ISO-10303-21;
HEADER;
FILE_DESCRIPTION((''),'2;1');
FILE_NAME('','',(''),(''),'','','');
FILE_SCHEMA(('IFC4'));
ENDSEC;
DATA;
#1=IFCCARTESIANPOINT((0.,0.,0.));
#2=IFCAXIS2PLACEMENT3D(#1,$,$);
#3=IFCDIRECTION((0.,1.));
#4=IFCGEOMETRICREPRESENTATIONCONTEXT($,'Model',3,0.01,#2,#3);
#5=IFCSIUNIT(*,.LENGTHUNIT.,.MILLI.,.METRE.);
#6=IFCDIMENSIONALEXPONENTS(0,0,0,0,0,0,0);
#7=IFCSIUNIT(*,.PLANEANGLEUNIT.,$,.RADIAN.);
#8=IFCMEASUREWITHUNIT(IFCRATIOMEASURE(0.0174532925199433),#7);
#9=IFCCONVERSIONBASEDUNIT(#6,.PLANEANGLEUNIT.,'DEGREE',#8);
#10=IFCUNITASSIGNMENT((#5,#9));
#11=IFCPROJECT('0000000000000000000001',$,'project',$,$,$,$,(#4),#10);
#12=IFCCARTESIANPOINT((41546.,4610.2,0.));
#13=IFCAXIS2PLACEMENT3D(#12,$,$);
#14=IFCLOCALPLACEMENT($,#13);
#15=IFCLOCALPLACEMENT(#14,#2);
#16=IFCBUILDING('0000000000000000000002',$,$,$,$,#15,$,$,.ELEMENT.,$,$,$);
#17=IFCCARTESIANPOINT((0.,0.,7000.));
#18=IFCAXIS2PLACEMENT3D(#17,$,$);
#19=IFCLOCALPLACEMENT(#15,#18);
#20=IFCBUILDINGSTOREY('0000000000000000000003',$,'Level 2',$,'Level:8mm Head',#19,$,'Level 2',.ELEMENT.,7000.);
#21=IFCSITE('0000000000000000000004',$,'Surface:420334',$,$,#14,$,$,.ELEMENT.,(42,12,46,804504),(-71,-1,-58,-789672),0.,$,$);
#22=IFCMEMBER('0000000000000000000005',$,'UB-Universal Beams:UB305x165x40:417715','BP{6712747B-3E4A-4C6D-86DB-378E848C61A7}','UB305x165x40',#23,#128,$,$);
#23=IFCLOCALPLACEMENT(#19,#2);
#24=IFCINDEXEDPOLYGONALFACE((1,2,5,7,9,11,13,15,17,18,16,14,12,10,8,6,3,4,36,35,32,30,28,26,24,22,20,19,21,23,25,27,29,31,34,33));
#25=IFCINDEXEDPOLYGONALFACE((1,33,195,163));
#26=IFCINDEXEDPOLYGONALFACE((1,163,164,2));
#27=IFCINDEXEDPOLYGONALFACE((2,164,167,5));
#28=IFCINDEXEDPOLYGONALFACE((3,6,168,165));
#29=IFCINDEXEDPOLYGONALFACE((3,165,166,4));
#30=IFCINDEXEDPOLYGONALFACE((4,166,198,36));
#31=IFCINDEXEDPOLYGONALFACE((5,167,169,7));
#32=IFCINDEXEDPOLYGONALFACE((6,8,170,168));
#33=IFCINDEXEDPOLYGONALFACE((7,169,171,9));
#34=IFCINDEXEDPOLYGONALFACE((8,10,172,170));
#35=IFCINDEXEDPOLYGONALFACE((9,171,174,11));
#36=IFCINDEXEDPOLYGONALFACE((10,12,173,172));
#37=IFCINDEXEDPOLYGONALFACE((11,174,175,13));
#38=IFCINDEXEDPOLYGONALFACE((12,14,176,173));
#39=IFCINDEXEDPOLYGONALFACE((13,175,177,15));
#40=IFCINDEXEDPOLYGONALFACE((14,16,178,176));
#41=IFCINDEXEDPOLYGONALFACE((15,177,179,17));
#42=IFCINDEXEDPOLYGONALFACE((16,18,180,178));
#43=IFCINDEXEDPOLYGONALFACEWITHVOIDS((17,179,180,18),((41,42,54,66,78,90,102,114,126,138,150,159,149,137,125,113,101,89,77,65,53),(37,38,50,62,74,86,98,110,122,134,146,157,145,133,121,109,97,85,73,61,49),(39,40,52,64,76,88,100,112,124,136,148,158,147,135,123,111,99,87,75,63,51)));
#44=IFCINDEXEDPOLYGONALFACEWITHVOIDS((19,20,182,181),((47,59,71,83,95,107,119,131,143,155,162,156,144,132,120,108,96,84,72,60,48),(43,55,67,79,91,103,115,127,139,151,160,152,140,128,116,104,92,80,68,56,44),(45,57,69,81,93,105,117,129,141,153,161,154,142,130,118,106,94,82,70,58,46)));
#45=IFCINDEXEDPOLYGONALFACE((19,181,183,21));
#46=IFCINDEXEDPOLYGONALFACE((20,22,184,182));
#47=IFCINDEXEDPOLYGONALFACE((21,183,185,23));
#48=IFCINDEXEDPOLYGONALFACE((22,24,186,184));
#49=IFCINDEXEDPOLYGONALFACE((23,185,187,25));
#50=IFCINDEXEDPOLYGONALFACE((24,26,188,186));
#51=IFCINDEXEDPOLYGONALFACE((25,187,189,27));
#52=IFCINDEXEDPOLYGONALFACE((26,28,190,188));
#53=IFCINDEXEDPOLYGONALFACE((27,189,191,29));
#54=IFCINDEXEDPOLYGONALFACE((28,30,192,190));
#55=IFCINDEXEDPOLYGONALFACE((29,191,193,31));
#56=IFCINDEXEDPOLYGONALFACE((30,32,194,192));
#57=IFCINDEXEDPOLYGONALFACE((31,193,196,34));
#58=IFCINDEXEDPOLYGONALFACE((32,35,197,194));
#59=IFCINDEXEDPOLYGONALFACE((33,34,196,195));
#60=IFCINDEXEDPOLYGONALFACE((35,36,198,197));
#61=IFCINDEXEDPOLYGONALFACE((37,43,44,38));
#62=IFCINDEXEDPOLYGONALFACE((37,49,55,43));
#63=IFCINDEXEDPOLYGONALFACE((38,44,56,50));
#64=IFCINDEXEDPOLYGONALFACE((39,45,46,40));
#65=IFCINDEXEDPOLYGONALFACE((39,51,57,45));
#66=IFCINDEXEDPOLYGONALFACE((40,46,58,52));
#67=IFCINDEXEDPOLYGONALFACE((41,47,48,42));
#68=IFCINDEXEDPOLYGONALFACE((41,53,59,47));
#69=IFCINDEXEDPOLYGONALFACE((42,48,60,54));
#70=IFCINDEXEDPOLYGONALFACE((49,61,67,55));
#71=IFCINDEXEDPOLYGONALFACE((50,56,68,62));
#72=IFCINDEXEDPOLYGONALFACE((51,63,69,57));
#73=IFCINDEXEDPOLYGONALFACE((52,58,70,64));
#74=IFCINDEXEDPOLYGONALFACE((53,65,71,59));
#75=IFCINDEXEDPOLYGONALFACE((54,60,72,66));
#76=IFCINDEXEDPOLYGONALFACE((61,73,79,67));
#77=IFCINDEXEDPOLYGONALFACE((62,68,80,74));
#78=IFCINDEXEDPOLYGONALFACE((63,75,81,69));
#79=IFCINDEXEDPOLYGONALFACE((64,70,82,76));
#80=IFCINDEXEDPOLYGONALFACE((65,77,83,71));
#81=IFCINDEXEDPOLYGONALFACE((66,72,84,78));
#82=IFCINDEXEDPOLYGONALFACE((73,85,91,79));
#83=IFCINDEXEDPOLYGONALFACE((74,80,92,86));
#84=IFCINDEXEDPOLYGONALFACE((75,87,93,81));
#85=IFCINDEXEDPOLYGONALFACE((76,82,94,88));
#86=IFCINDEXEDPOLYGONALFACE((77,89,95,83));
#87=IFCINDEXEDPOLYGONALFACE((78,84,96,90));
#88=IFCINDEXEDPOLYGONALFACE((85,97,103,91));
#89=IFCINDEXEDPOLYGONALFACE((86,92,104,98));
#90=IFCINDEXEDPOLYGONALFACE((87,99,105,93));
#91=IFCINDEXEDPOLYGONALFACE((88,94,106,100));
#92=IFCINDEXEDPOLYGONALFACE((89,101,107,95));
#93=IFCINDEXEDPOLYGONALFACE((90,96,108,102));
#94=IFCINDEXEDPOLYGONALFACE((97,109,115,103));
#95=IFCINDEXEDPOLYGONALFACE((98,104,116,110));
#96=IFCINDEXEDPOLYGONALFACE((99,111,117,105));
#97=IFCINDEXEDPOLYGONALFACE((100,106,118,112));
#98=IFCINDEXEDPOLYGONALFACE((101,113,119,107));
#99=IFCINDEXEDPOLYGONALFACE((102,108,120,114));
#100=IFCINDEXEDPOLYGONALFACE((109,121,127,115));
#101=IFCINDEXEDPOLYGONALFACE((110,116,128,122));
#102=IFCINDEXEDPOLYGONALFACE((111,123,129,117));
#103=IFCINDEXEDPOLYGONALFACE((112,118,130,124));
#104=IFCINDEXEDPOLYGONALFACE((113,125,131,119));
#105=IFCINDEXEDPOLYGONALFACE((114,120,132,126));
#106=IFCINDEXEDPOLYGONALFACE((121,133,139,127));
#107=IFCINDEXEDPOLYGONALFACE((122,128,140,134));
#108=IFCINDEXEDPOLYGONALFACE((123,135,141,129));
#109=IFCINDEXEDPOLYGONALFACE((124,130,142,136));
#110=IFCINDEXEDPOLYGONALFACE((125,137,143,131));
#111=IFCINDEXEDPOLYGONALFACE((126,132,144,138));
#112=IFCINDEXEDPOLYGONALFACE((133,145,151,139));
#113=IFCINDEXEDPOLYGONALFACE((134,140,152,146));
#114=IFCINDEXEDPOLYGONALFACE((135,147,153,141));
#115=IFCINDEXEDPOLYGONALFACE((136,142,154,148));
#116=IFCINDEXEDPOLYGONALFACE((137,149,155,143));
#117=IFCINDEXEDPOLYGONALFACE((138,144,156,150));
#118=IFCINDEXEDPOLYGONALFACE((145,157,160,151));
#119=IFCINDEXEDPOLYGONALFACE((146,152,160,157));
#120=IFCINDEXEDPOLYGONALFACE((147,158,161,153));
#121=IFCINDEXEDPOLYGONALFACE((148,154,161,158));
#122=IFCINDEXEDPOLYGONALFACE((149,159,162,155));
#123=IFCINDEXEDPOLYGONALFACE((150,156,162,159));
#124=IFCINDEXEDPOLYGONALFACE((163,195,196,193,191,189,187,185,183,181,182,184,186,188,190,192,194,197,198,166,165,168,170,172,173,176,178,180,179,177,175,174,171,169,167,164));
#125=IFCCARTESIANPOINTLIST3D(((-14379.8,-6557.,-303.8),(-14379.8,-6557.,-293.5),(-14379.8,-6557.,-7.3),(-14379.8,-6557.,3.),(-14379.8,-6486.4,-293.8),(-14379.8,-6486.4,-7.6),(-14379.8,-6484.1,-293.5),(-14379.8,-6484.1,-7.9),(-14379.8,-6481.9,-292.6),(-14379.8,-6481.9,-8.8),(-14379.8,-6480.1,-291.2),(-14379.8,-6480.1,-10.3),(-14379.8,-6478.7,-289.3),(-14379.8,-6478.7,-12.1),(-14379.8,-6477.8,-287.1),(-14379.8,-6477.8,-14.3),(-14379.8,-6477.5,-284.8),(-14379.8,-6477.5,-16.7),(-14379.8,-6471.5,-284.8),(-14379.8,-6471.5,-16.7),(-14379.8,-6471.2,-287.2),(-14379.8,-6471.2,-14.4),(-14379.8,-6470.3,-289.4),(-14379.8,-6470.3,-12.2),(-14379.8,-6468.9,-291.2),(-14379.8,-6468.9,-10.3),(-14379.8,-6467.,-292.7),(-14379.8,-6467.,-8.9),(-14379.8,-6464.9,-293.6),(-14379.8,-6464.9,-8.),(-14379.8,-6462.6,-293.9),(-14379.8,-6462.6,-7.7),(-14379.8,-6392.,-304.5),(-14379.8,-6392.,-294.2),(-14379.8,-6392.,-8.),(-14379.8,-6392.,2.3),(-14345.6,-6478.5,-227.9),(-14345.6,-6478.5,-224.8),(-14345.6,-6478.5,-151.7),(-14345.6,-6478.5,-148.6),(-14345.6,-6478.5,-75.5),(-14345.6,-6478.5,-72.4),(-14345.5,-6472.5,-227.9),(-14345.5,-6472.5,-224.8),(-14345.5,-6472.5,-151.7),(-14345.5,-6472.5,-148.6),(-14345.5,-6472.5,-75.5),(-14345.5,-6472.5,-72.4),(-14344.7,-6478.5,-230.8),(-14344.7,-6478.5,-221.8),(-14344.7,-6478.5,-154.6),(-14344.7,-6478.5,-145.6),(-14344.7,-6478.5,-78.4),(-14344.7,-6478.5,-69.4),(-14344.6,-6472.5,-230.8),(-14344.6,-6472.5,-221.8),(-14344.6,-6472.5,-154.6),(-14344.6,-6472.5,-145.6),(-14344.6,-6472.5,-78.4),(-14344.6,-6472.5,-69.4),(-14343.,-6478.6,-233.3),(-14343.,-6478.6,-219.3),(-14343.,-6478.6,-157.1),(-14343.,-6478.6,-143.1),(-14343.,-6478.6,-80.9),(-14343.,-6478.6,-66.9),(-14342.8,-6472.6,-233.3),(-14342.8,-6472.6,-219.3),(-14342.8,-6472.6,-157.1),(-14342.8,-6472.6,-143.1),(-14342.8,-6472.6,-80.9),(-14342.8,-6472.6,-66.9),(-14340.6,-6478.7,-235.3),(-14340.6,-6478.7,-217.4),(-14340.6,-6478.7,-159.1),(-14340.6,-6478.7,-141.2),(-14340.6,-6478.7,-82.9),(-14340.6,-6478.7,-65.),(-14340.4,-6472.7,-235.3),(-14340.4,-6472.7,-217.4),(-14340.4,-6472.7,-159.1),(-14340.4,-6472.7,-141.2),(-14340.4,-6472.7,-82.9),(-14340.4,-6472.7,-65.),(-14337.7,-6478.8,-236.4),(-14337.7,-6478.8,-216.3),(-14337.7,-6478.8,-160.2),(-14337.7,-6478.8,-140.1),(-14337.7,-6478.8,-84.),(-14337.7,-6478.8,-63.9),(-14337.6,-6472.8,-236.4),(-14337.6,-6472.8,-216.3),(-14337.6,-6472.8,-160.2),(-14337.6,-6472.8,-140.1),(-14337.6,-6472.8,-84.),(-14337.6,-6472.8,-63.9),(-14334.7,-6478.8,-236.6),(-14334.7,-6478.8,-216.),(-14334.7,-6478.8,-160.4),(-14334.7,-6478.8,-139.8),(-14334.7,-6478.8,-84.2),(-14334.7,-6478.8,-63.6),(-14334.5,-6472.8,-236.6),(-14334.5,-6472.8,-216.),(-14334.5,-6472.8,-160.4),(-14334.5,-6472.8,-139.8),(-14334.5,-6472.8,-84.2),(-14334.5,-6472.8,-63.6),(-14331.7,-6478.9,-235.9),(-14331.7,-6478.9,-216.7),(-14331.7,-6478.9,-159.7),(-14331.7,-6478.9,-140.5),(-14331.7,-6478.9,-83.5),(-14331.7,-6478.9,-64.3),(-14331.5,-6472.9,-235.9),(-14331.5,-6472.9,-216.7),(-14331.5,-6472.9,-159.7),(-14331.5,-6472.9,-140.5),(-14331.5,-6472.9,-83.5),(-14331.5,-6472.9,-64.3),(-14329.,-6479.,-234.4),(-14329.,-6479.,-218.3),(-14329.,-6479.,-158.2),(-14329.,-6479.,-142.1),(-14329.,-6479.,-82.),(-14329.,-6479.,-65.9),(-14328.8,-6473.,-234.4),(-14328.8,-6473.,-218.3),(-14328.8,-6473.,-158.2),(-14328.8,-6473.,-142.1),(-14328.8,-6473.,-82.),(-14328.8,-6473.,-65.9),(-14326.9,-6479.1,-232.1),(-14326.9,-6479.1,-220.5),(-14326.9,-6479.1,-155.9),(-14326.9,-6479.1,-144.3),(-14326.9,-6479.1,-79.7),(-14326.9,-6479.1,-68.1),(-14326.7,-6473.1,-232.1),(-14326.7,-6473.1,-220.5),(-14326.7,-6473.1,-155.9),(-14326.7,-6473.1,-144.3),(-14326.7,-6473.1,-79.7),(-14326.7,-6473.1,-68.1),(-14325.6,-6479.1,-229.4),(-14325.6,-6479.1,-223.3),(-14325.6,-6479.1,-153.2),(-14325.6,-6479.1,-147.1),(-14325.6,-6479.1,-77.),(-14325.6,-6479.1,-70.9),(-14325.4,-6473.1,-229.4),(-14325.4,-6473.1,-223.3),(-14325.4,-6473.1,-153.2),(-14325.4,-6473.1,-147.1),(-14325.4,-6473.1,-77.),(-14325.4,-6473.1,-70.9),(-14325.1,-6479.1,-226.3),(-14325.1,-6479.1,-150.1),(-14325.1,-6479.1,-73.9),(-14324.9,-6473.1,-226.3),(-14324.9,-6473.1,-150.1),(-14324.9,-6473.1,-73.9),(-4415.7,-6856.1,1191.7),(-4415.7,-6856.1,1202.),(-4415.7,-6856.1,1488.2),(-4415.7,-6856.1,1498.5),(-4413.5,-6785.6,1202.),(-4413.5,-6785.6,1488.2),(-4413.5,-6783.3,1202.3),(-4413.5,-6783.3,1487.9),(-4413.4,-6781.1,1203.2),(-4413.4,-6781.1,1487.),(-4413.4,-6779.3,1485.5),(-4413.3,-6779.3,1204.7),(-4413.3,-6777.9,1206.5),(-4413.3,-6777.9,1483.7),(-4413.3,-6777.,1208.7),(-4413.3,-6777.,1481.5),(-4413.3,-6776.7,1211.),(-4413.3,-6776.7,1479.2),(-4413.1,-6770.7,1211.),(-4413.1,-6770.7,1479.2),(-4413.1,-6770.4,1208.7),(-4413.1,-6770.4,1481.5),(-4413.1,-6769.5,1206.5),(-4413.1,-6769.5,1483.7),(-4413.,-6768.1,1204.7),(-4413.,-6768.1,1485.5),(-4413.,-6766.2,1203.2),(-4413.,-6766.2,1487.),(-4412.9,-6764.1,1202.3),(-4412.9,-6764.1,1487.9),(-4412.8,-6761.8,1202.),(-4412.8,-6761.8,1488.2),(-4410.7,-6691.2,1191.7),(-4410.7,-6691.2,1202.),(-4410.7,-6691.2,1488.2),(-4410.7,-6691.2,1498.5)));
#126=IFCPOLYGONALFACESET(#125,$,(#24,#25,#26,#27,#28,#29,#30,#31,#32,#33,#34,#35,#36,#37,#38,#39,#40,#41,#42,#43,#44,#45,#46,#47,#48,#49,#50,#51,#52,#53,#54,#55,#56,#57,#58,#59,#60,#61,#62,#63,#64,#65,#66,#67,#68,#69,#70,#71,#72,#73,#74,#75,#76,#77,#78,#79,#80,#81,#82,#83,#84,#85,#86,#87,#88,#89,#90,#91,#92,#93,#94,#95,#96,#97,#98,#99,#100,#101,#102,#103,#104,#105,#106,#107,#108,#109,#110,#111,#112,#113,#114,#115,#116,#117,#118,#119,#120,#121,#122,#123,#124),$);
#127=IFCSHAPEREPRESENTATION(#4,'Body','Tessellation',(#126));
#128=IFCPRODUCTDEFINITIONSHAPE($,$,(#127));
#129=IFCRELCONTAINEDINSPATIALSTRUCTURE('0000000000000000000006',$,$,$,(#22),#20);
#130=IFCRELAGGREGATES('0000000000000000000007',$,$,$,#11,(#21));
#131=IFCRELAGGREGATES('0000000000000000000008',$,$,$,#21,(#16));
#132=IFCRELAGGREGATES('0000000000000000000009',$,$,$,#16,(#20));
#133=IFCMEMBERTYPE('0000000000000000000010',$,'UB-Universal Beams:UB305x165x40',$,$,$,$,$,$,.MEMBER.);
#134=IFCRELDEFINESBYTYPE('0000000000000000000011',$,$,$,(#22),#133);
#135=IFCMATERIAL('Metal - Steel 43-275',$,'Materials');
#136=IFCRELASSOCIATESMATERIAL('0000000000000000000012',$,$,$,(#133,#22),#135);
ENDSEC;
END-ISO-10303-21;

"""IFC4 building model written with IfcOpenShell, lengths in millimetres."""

from ifc_helpers import new_model, entity, si_unit, converted_unit, direction, frame, frame_2d, origin, origin_2d, origin_2d_with_axis, place, context, project, spatial, circle, i_section, extrude, clip, halfspace, material, type_object, element, save


model = new_model("IFC4")

# Units and contexts
model_context = context("Model", 3, precision=0.01, world=origin(), true_north=direction((0.0, 1.0)))
ifc_project = project(units=[si_unit("LENGTHUNIT", "METRE", prefix="MILLI"), converted_unit("PLANEANGLEUNIT", "DEGREE", entity("IfcRatioMeasure", 0.0174532925199433), si_unit("PLANEANGLEUNIT", "RADIAN"), dimensions=[0, 0, 0, 0, 0, 0, 0])], contexts=[model_context])

# Site, building, storey
site_placement = place(None, frame((41546.0, 4610.2, 0.0)))
site = spatial("IfcSite", under=ifc_project, at=site_placement, Name="Surface:420334", CompositionType="ELEMENT", RefLatitude=(42, 12, 46, 804504), RefLongitude=(-71, -1, -58, -789672), RefElevation=0.0)
building_placement = place(site_placement, origin())
building = spatial("IfcBuilding", under=site, at=building_placement, CompositionType="ELEMENT")
storey_placement = place(building_placement, frame((0.0, 0.0, 7000.0)))
storey = spatial("IfcBuildingStorey", under=building, at=storey_placement, Name="Level 2", ObjectType="Level:8mm Head", LongName="Level 2", CompositionType="ELEMENT", Elevation=7000.0)

# Shared definitions
ifc_material = material(Name="Metal - Steel 43-275", Category="Materials")

# Member, openings
member_type_1 = type_object("IfcMemberType", Name="UB-Universal Beams:UB305x165x40", PredefinedType="MEMBER", material=ifc_material)
member_1_placement = place(storey_placement, frame((-14851.0, -6460.3, -221.5), z_axis=(-0.988488, 0.029672, -0.148359), x_axis=(-0.030004, -0.99955, 0.0)))
member_1 = element("IfcMember", 1, at=member_1_placement, inside=storey, type_object=member_type_1, material=ifc_material, Name="UB-Universal Beams:UB305x165x40:417715", Description="BP{6712747B-3E4A-4C6D-86DB-378E848C61A7}", ObjectType="UB305x165x40", context=model_context, shape_type="Clipping", body=[
    clip(clip(extrude(i_section(OverallWidth=165.0, OverallDepth=303.4, WebThickness=6.0, FlangeThickness=10.2, FilletRadius=8.9, at=origin_2d()), origin(), (0.0, 0.0, -1.0), 11073.7), halfspace(frame((-6903.0, -8252.9, -9321.5), z_axis=(0.0, 0.14834, 0.988936), x_axis=(1.0, 0.0, 0.0)), True)), halfspace(frame((-6471.6, -6744.6, 731.5), z_axis=(-0.030004, -0.148292, -0.988488), x_axis=(-0.99955, 0.004451, 0.029672)), True)),
])
opening_1_placement = place(member_1_placement, frame((3.5, -6.0, -520.8), z_axis=(-1.0, 0.0, 0.0), x_axis=(0.0, -0.148359, -0.988934)))
element("IfcOpeningElement", 2, at=opening_1_placement, cuts=member_1, ObjectType="Opening", context=model_context, shape_type="SweptSolid", body=[
    extrude(circle(Radius=10.3, at=origin_2d_with_axis()), origin(), (0.0, 0.0, 1.0), 7.0),
])
opening_2_placement = place(member_1_placement, frame((3.5, -6.0, -520.8), z_axis=(-1.0, 0.0, 0.0), x_axis=(0.0, -0.148359, -0.988934)))
element("IfcOpeningElement", 3, at=opening_2_placement, cuts=member_1, ObjectType="Opening", context=model_context, shape_type="SweptSolid", body=[
    extrude(circle(Radius=10.3, at=frame_2d((0.0, 76.2), x_axis=(1.0, 0.0))), origin(), (0.0, 0.0, 1.0), 7.0),
])
opening_3_placement = place(member_1_placement, frame((3.5, -6.0, -520.8), z_axis=(-1.0, 0.0, 0.0), x_axis=(0.0, -0.148359, -0.988934)))
element("IfcOpeningElement", 4, at=opening_3_placement, cuts=member_1, ObjectType="Opening", context=model_context, shape_type="SweptSolid", body=[
    extrude(circle(Radius=10.3, at=frame_2d((0.0, -76.2), x_axis=(1.0, 0.0))), origin(), (0.0, 0.0, 1.0), 7.0),
])

save(model, "model.ifc")
